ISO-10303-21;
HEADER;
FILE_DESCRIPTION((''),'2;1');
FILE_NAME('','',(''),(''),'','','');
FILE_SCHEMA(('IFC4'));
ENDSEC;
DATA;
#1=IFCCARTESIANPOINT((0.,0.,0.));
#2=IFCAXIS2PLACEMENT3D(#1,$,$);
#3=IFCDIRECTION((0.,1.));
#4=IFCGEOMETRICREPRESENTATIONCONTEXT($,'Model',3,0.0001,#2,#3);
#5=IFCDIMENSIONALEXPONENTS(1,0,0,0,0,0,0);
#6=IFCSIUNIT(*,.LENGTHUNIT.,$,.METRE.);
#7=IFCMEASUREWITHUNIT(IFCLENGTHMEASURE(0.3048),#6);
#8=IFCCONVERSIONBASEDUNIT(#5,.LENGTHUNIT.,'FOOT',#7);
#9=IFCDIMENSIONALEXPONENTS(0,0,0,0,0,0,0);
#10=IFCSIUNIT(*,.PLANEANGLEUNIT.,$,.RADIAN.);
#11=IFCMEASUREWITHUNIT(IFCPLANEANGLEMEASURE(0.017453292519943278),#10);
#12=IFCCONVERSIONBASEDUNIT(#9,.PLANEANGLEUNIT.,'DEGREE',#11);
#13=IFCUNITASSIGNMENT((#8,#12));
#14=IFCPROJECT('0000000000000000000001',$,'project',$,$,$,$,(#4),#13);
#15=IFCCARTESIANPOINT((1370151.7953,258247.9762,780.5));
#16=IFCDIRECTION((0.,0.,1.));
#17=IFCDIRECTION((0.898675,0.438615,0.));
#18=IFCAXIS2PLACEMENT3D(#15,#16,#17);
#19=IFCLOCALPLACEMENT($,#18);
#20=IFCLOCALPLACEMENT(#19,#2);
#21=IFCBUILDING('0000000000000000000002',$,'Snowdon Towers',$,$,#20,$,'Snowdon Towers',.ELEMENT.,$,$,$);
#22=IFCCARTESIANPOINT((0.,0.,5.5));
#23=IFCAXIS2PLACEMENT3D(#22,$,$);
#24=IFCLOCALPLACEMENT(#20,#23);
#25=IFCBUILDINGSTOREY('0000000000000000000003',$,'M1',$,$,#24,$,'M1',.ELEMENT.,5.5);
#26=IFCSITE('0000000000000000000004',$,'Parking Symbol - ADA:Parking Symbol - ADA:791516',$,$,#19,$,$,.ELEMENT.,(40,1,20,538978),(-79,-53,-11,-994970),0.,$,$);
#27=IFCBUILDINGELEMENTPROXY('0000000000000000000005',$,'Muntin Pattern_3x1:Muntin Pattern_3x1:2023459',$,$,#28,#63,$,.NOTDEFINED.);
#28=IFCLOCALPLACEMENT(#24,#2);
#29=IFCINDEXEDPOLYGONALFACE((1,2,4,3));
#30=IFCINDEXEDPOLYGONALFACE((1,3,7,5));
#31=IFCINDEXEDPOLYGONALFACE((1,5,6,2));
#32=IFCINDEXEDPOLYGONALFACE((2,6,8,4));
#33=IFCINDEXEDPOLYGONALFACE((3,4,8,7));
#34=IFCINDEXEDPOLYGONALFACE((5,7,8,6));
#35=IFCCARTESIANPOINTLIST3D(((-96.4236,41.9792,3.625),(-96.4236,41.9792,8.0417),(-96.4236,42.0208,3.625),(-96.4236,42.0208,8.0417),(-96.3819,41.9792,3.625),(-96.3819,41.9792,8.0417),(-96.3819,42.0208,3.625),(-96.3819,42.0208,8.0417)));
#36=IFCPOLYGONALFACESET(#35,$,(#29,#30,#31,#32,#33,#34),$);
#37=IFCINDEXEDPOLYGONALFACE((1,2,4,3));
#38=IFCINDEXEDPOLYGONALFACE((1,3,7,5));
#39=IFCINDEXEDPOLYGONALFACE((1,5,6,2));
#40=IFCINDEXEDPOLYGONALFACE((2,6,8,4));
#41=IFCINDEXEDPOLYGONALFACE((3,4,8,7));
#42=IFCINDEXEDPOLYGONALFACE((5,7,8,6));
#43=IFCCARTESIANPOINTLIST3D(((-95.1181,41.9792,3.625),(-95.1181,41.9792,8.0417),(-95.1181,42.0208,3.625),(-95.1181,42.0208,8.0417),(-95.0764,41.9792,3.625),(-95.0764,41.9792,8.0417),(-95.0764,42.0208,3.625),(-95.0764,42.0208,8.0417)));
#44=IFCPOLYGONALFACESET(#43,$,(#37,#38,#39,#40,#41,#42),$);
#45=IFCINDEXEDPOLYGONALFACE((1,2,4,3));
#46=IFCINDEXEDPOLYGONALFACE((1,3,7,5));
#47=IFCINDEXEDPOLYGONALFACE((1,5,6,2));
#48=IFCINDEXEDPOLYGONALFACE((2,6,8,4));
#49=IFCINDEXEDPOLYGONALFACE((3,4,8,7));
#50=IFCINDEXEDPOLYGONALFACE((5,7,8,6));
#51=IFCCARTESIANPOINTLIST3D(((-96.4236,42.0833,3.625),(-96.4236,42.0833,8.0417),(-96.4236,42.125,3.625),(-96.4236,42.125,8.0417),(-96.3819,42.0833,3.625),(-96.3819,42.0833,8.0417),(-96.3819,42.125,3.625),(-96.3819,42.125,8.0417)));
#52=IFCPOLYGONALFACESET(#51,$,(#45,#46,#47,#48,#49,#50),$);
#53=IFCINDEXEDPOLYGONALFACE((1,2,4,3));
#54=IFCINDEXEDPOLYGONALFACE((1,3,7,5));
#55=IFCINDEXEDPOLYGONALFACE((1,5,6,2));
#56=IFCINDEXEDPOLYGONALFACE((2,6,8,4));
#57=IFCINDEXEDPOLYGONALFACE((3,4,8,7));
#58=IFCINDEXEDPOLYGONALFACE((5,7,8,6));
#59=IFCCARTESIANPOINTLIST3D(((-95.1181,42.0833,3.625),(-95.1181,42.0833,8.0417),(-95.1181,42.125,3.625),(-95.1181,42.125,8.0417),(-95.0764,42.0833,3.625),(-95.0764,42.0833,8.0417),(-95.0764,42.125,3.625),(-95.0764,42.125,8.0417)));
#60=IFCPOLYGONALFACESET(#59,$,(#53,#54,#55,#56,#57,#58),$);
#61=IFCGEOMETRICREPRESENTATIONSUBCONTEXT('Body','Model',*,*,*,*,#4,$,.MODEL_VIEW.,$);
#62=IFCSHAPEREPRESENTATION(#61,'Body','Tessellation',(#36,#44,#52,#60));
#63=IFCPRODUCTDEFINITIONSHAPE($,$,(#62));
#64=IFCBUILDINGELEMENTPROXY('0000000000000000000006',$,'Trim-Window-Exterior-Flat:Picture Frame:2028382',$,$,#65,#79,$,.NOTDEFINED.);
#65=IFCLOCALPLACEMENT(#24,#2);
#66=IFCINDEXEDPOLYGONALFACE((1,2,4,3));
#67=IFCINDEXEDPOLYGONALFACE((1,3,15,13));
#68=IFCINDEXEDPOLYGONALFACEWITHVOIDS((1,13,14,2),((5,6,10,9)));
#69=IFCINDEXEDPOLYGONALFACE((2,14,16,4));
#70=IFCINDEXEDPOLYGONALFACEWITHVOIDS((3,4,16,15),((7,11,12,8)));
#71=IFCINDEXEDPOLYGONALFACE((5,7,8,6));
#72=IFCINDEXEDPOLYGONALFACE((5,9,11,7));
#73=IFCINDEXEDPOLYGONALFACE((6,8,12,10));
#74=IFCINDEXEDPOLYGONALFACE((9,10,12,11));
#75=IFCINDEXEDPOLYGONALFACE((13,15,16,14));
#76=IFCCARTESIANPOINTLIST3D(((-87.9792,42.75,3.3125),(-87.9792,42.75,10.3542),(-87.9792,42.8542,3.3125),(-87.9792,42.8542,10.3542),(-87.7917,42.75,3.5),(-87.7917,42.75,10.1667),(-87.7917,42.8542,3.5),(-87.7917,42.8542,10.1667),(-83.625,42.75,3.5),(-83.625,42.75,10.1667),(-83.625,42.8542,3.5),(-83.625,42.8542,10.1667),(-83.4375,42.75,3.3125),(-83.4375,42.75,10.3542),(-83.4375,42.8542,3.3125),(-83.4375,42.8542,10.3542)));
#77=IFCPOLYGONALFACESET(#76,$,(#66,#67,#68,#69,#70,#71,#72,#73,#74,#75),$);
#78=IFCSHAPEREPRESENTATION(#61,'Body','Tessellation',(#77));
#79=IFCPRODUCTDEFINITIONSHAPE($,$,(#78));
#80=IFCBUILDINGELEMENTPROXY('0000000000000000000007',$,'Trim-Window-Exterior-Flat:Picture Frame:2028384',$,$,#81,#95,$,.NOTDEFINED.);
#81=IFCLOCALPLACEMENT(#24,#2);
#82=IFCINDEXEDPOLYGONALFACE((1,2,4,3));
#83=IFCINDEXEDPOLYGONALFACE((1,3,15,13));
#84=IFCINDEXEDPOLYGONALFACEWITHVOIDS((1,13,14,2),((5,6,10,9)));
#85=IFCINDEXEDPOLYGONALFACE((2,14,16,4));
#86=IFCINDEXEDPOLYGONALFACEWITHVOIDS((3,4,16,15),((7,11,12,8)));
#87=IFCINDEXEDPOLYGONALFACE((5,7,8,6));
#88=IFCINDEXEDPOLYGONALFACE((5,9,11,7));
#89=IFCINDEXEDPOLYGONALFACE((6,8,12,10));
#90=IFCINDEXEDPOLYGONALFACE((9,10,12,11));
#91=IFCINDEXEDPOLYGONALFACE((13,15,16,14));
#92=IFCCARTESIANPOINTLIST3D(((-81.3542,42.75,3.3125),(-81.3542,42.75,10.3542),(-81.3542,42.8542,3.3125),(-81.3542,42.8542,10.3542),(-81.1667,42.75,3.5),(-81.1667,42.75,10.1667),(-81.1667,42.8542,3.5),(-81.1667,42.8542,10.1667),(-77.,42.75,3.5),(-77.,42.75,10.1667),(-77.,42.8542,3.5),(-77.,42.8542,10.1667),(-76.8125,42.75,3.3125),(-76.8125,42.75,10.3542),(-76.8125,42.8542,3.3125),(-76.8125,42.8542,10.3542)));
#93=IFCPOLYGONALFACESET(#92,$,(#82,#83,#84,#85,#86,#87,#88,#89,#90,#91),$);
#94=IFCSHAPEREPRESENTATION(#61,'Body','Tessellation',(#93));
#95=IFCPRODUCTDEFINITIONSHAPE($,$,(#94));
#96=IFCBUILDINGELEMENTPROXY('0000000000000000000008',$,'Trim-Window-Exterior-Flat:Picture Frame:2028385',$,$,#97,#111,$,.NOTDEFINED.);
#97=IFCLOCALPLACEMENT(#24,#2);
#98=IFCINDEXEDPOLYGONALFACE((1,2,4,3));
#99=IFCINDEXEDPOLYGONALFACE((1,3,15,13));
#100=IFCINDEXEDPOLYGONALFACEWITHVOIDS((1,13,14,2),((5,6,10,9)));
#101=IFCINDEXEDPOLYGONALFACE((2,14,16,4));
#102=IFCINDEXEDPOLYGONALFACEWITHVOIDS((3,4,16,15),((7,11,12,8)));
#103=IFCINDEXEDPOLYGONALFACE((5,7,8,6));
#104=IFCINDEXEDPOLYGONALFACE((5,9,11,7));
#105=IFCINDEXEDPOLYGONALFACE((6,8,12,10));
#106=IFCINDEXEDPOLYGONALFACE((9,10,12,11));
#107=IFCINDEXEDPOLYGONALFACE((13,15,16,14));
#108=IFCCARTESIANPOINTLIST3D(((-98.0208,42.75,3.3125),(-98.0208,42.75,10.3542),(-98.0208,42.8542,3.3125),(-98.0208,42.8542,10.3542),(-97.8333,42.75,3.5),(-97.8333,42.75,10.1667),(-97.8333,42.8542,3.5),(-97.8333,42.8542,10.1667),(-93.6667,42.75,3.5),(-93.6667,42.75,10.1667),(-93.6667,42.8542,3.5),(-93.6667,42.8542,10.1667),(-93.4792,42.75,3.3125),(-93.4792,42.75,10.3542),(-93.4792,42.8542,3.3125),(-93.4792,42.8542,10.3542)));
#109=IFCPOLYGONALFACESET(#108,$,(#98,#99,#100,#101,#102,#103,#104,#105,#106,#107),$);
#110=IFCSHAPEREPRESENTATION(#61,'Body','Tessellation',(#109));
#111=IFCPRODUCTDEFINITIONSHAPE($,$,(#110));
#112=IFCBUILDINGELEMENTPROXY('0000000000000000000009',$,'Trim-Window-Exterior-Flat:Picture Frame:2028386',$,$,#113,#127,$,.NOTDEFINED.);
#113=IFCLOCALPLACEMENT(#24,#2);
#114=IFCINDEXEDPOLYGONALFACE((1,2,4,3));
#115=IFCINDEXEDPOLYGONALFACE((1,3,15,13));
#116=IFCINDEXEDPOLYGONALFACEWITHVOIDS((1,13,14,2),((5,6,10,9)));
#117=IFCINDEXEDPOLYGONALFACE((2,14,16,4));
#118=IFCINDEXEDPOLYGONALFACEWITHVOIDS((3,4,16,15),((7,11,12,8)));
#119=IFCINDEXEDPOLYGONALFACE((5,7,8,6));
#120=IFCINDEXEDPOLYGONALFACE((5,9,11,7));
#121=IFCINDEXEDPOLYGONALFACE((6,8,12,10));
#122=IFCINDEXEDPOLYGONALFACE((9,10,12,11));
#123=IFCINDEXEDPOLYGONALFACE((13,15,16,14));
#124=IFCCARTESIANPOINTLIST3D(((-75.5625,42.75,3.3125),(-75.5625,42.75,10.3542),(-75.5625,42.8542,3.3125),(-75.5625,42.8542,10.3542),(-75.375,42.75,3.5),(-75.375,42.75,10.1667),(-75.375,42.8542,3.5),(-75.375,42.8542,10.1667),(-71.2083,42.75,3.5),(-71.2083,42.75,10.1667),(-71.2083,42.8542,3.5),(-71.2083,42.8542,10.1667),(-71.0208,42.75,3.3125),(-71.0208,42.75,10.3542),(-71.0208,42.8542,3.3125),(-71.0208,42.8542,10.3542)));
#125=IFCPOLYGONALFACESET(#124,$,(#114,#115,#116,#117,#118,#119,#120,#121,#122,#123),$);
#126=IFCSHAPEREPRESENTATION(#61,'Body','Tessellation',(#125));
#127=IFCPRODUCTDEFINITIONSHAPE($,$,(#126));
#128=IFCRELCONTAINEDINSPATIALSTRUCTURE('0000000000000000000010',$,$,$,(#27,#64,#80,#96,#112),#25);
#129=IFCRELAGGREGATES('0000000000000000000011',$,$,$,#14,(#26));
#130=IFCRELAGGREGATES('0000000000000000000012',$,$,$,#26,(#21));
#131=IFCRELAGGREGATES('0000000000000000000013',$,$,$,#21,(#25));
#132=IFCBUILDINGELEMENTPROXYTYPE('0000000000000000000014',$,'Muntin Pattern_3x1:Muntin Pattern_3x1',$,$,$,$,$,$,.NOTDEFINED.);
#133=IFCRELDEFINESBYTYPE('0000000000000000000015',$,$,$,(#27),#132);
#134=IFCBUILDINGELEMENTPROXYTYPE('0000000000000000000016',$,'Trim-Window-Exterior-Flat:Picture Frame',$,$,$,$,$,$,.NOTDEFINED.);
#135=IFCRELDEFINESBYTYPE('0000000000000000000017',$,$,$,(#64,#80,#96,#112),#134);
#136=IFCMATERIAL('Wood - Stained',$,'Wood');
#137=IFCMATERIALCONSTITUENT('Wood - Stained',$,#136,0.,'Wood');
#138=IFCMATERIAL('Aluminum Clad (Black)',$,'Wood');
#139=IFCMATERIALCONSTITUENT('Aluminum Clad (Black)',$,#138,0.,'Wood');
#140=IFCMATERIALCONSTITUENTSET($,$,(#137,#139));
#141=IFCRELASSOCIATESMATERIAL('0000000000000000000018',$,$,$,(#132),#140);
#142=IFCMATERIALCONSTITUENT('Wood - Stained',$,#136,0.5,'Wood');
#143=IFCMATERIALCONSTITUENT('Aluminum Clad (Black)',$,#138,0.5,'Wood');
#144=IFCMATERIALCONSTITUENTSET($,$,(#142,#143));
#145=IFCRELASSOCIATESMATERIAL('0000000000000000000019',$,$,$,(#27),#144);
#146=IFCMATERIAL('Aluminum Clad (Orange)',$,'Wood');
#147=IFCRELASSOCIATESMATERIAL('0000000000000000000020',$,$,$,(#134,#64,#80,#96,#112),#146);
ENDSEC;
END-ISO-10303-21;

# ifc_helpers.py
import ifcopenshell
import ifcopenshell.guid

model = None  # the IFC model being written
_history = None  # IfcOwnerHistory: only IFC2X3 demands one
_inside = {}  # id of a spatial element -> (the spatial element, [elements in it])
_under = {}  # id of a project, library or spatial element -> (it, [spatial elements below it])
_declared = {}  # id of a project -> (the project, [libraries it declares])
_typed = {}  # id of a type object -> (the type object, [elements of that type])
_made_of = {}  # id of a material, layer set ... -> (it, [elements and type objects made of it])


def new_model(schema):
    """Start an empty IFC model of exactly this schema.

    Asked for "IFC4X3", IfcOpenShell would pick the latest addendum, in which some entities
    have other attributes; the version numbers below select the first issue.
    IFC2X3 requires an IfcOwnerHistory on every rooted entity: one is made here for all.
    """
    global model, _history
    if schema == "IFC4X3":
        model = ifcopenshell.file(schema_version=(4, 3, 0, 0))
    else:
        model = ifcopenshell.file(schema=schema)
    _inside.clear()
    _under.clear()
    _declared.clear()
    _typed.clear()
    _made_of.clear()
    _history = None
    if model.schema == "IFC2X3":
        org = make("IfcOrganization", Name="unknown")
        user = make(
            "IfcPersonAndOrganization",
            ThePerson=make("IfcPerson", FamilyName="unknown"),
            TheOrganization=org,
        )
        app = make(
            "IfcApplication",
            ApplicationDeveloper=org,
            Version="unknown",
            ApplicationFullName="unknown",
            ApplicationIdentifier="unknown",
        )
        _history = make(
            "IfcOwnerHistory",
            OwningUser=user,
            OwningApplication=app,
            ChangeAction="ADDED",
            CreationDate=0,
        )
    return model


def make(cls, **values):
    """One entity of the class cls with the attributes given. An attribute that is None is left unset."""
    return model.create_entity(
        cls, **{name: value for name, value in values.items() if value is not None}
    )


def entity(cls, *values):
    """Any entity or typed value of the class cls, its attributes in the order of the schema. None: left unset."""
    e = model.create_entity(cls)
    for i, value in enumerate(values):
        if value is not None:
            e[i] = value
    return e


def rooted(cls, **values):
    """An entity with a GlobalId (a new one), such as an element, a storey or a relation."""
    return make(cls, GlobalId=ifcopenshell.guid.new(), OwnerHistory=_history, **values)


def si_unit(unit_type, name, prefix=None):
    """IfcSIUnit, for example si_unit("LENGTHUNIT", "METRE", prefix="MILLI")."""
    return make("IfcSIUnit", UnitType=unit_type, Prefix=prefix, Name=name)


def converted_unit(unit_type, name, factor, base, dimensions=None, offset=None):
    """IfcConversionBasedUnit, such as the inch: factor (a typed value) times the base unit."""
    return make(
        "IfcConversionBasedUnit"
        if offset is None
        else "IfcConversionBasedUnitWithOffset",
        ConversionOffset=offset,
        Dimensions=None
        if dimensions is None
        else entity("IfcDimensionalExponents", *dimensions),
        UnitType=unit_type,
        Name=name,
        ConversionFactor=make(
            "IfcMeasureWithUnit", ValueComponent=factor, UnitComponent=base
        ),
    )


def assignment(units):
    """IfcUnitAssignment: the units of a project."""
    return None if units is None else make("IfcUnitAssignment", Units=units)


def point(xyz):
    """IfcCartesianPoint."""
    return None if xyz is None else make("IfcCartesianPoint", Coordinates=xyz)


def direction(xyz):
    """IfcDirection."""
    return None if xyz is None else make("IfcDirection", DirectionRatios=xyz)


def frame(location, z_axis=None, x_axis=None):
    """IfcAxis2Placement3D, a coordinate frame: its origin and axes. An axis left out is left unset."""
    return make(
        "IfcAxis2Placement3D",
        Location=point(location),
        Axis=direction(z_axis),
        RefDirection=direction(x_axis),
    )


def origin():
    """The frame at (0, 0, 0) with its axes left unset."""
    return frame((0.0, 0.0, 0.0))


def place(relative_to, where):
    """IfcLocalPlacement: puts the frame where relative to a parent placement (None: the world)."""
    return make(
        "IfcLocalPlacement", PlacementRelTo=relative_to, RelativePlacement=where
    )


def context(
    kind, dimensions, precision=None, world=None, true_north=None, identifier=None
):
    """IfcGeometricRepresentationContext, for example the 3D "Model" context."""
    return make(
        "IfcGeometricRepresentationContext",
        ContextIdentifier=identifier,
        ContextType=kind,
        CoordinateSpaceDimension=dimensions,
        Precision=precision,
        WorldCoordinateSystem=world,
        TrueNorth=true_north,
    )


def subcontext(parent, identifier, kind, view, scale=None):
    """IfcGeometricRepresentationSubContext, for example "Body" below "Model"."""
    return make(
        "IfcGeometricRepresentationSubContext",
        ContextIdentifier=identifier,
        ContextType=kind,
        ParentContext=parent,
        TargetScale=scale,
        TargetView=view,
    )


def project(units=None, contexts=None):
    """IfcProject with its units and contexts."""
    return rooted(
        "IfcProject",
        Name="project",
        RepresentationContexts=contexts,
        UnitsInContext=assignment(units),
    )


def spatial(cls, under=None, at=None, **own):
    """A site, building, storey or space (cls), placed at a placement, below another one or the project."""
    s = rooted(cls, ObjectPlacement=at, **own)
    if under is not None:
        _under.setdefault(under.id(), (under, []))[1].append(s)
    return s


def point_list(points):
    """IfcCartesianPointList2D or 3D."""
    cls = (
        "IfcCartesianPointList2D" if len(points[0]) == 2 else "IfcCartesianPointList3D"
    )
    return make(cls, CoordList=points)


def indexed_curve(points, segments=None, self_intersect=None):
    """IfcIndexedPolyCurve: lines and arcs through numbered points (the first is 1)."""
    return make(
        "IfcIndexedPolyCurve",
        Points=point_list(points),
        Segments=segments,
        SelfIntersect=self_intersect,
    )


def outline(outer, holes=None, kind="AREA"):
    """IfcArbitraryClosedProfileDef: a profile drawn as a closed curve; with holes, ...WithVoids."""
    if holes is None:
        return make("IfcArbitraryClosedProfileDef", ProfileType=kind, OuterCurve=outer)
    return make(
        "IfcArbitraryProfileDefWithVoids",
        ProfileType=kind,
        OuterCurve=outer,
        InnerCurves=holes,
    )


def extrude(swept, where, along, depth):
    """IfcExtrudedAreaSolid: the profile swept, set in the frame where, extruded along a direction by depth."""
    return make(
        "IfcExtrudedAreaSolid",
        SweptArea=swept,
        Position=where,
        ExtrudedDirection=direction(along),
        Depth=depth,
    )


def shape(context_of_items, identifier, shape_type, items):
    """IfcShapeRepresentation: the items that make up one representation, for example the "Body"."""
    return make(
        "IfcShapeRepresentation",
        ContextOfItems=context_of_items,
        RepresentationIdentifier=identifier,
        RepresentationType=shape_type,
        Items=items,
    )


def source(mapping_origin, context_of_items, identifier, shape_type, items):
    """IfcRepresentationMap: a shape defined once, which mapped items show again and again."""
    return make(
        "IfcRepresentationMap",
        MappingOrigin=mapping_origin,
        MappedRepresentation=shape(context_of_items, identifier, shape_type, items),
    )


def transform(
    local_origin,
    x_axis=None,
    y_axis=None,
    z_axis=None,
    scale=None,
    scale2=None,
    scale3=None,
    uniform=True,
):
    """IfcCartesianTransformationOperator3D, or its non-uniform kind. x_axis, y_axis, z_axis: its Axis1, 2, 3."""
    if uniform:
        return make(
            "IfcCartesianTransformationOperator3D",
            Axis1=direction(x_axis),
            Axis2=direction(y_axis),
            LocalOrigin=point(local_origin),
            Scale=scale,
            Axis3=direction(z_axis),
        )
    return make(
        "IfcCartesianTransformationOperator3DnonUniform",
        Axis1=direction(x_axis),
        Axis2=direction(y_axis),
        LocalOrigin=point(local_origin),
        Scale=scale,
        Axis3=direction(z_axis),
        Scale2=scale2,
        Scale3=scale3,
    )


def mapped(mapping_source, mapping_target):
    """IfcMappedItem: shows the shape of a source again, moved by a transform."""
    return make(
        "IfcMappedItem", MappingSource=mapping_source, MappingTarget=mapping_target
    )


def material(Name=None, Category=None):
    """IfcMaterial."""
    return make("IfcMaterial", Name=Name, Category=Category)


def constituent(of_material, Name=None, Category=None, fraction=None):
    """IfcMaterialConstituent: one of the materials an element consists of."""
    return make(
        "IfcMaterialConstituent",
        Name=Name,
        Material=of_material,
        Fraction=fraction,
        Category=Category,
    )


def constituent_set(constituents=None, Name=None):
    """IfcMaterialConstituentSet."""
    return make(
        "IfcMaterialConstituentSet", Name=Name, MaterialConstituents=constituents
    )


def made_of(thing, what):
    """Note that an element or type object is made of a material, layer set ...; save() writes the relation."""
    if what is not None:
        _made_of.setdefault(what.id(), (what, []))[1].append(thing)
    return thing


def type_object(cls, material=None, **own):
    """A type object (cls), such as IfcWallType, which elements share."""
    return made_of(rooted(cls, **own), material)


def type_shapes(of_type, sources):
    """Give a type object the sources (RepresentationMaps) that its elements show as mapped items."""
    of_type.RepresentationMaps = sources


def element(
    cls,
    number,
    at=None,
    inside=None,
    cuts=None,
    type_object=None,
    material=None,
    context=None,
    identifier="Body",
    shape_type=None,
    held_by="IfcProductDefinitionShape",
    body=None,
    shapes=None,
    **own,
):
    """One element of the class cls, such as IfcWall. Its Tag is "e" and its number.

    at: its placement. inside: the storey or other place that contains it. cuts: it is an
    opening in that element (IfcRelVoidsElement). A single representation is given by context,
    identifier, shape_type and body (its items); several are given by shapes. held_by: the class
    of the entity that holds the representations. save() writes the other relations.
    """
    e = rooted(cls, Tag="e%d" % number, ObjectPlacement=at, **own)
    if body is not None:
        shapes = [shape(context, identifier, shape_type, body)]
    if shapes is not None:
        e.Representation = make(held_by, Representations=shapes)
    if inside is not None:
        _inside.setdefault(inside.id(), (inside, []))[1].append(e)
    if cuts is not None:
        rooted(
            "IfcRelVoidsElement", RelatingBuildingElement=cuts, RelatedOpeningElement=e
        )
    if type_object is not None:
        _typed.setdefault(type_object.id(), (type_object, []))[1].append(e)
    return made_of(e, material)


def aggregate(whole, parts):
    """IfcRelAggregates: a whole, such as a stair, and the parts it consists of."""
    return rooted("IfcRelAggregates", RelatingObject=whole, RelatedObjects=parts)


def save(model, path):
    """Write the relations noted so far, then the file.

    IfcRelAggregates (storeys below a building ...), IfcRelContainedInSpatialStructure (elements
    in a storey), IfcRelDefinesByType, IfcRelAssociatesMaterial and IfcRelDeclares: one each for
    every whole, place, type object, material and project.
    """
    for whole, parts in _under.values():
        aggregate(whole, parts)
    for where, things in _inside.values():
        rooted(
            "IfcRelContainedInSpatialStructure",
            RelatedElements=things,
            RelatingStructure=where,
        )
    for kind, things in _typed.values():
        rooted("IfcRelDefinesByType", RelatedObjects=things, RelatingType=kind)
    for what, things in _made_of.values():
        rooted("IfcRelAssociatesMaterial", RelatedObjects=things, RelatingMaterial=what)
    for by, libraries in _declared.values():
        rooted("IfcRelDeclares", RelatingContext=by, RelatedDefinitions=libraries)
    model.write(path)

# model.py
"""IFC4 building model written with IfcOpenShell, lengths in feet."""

from ifc_helpers import new_model, entity, si_unit, converted_unit, direction, frame, origin, place, context, subcontext, project, spatial, indexed_curve, outline, extrude, source, transform, mapped, material, constituent, constituent_set, type_object, type_shapes, element, save


model = new_model("IFC4")

# Units and contexts
model_context = context("Model", 3, precision=0.0001, world=origin(), true_north=direction((0.0, 1.0)))
body_context = subcontext(model_context, "Body", "Model", "MODEL_VIEW")
ifc_project = project(units=[converted_unit("LENGTHUNIT", "FOOT", entity("IfcLengthMeasure", 0.3048), si_unit("LENGTHUNIT", "METRE"), dimensions=[1, 0, 0, 0, 0, 0, 0]), converted_unit("PLANEANGLEUNIT", "DEGREE", entity("IfcPlaneAngleMeasure", 0.017453292519943278), si_unit("PLANEANGLEUNIT", "RADIAN"), dimensions=[0, 0, 0, 0, 0, 0, 0])], contexts=[model_context])

# Site, building, storey
site_placement = place(None, frame((1370151.7953, 258247.9762, 780.5), z_axis=(0.0, 0.0, 1.0), x_axis=(0.898675, 0.438615, 0.0)))
site = spatial("IfcSite", under=ifc_project, at=site_placement, Name="Parking Symbol - ADA:Parking Symbol - ADA:791516", CompositionType="ELEMENT", RefLatitude=(40, 1, 20, 538978), RefLongitude=(-79, -53, -11, -994970), RefElevation=0.0)
building_placement = place(site_placement, origin())
building = spatial("IfcBuilding", under=site, at=building_placement, Name="Snowdon Towers", LongName="Snowdon Towers", CompositionType="ELEMENT")
storey_placement = place(building_placement, frame((0.0, 0.0, 5.5)))
storey = spatial("IfcBuildingStorey", under=building, at=storey_placement, Name="M1", LongName="M1", CompositionType="ELEMENT", Elevation=5.5)

# Building element proxies
ifc_material_1 = material(Name="Wood - Stained", Category="Wood")
ifc_material_2 = material(Name="Aluminum Clad (Black)", Category="Wood")
ifc_constituent_1 = constituent(ifc_material_1, Name="Wood - Stained", Category="Wood", fraction=0.0)
ifc_constituent_2 = constituent(ifc_material_2, Name="Aluminum Clad (Black)", Category="Wood", fraction=0.0)
ifc_constituent_set_1 = constituent_set(constituents=[ifc_constituent_1, ifc_constituent_2])
building_element_proxy_type_1 = type_object("IfcBuildingElementProxyType", Name="Muntin Pattern_3x1:Muntin Pattern_3x1", PredefinedType="NOTDEFINED", material=ifc_constituent_set_1)
shared_shape_1 = source(origin(), body_context, "Body", "SweptSolid", [
    extrude(outline(indexed_curve([(-0.0208, -0.0208), (0.0208, -0.0208), (0.0208, 0.0208), (-0.0208, 0.0208), (-0.0208, -0.0208)], self_intersect=False)), frame((0.6528, 0.0521, 0.0)), (0.0, 0.0, 1.0), 4.4167),
    extrude(outline(indexed_curve([(-0.0208, -0.0208), (0.0208, -0.0208), (0.0208, 0.0208), (-0.0208, 0.0208), (-0.0208, -0.0208)], self_intersect=False)), frame((-0.6528, 0.0521, 0.0)), (0.0, 0.0, 1.0), 4.4167),
    extrude(outline(indexed_curve([(-0.0208, -0.0208), (0.0208, -0.0208), (0.0208, 0.0208), (-0.0208, 0.0208), (-0.0208, -0.0208)], self_intersect=False)), frame((0.6528, -0.0521, 0.0)), (0.0, 0.0, 1.0), 4.4167),
    extrude(outline(indexed_curve([(-0.0208, -0.0208), (0.0208, -0.0208), (0.0208, 0.0208), (-0.0208, 0.0208), (-0.0208, -0.0208)], self_intersect=False)), frame((-0.6528, -0.0521, 0.0)), (0.0, 0.0, 1.0), 4.4167),
])
type_shapes(building_element_proxy_type_1, [shared_shape_1])
ifc_constituent_3 = constituent(ifc_material_1, Name="Wood - Stained", Category="Wood", fraction=0.5)
ifc_constituent_4 = constituent(ifc_material_2, Name="Aluminum Clad (Black)", Category="Wood", fraction=0.5)
ifc_constituent_set_2 = constituent_set(constituents=[ifc_constituent_3, ifc_constituent_4])
proxy_1_placement = place(storey_placement, frame((-95.75, 42.0521, 3.625), z_axis=(0.0, 0.0, 1.0), x_axis=(-1.0, 0.0, 0.0)))
element("IfcBuildingElementProxy", 1, at=proxy_1_placement, inside=storey, type_object=building_element_proxy_type_1, material=ifc_constituent_set_2, Name="Muntin Pattern_3x1:Muntin Pattern_3x1:2023459", PredefinedType="NOTDEFINED", context=body_context, shape_type="MappedRepresentation", body=[
    mapped(shared_shape_1, transform((0.0, 0.0, 0.0), scale=1.0)),
])
ifc_material_3 = material(Name="Aluminum Clad (Orange)", Category="Wood")
building_element_proxy_type_2 = type_object("IfcBuildingElementProxyType", Name="Trim-Window-Exterior-Flat:Picture Frame", PredefinedType="NOTDEFINED", material=ifc_material_3)
shared_shape_2 = source(origin(), body_context, "Body", "SweptSolid", [
    extrude(outline(indexed_curve([(-2.2708, -3.5208), (2.2708, -3.5208), (2.2708, 3.5208), (-2.2708, 3.5208), (-2.2708, -3.5208)], self_intersect=False), holes=[indexed_curve([(-2.0833, -3.3333), (-2.0833, 3.3333), (2.0833, 3.3333), (2.0833, -3.3333), (-2.0833, -3.3333)], self_intersect=False)]), frame((0.0, -3.3333, 0.0), z_axis=(0.0, 0.0, 1.0), x_axis=(-1.0, 0.0, 0.0)), (0.0, 0.0, 1.0), 0.1042),
])
type_shapes(building_element_proxy_type_2, [shared_shape_2])
for number, where, z_axis, x_axis, name in (
    (2, (-85.7083, 42.75, 10.1667), (0.0, 1.0, 0.0), (-1.0, 0.0, 0.0), "Trim-Window-Exterior-Flat:Picture Frame:2028382"),
    (3, (-79.0833, 42.75, 10.1667), (0.0, 1.0, 0.0), (-1.0, 0.0, 0.0), "Trim-Window-Exterior-Flat:Picture Frame:2028384"),
    (4, (-95.75, 42.75, 10.1667), (0.0, 1.0, 0.0), (-1.0, 0.0, 0.0), "Trim-Window-Exterior-Flat:Picture Frame:2028385"),
    (5, (-73.2917, 42.75, 10.1667), (0.0, 1.0, 0.0), (-1.0, 0.0, 0.0), "Trim-Window-Exterior-Flat:Picture Frame:2028386"),
):
    element("IfcBuildingElementProxy", number, at=place(storey_placement, frame(where, z_axis=z_axis, x_axis=x_axis)), inside=storey, type_object=building_element_proxy_type_2, material=ifc_material_3, Name=name, PredefinedType="NOTDEFINED", context=body_context, shape_type="MappedRepresentation", body=[
        mapped(shared_shape_2, transform((0.0, 0.0, 0.0), scale=1.0)),
    ])

save(model, "model.ifc")
